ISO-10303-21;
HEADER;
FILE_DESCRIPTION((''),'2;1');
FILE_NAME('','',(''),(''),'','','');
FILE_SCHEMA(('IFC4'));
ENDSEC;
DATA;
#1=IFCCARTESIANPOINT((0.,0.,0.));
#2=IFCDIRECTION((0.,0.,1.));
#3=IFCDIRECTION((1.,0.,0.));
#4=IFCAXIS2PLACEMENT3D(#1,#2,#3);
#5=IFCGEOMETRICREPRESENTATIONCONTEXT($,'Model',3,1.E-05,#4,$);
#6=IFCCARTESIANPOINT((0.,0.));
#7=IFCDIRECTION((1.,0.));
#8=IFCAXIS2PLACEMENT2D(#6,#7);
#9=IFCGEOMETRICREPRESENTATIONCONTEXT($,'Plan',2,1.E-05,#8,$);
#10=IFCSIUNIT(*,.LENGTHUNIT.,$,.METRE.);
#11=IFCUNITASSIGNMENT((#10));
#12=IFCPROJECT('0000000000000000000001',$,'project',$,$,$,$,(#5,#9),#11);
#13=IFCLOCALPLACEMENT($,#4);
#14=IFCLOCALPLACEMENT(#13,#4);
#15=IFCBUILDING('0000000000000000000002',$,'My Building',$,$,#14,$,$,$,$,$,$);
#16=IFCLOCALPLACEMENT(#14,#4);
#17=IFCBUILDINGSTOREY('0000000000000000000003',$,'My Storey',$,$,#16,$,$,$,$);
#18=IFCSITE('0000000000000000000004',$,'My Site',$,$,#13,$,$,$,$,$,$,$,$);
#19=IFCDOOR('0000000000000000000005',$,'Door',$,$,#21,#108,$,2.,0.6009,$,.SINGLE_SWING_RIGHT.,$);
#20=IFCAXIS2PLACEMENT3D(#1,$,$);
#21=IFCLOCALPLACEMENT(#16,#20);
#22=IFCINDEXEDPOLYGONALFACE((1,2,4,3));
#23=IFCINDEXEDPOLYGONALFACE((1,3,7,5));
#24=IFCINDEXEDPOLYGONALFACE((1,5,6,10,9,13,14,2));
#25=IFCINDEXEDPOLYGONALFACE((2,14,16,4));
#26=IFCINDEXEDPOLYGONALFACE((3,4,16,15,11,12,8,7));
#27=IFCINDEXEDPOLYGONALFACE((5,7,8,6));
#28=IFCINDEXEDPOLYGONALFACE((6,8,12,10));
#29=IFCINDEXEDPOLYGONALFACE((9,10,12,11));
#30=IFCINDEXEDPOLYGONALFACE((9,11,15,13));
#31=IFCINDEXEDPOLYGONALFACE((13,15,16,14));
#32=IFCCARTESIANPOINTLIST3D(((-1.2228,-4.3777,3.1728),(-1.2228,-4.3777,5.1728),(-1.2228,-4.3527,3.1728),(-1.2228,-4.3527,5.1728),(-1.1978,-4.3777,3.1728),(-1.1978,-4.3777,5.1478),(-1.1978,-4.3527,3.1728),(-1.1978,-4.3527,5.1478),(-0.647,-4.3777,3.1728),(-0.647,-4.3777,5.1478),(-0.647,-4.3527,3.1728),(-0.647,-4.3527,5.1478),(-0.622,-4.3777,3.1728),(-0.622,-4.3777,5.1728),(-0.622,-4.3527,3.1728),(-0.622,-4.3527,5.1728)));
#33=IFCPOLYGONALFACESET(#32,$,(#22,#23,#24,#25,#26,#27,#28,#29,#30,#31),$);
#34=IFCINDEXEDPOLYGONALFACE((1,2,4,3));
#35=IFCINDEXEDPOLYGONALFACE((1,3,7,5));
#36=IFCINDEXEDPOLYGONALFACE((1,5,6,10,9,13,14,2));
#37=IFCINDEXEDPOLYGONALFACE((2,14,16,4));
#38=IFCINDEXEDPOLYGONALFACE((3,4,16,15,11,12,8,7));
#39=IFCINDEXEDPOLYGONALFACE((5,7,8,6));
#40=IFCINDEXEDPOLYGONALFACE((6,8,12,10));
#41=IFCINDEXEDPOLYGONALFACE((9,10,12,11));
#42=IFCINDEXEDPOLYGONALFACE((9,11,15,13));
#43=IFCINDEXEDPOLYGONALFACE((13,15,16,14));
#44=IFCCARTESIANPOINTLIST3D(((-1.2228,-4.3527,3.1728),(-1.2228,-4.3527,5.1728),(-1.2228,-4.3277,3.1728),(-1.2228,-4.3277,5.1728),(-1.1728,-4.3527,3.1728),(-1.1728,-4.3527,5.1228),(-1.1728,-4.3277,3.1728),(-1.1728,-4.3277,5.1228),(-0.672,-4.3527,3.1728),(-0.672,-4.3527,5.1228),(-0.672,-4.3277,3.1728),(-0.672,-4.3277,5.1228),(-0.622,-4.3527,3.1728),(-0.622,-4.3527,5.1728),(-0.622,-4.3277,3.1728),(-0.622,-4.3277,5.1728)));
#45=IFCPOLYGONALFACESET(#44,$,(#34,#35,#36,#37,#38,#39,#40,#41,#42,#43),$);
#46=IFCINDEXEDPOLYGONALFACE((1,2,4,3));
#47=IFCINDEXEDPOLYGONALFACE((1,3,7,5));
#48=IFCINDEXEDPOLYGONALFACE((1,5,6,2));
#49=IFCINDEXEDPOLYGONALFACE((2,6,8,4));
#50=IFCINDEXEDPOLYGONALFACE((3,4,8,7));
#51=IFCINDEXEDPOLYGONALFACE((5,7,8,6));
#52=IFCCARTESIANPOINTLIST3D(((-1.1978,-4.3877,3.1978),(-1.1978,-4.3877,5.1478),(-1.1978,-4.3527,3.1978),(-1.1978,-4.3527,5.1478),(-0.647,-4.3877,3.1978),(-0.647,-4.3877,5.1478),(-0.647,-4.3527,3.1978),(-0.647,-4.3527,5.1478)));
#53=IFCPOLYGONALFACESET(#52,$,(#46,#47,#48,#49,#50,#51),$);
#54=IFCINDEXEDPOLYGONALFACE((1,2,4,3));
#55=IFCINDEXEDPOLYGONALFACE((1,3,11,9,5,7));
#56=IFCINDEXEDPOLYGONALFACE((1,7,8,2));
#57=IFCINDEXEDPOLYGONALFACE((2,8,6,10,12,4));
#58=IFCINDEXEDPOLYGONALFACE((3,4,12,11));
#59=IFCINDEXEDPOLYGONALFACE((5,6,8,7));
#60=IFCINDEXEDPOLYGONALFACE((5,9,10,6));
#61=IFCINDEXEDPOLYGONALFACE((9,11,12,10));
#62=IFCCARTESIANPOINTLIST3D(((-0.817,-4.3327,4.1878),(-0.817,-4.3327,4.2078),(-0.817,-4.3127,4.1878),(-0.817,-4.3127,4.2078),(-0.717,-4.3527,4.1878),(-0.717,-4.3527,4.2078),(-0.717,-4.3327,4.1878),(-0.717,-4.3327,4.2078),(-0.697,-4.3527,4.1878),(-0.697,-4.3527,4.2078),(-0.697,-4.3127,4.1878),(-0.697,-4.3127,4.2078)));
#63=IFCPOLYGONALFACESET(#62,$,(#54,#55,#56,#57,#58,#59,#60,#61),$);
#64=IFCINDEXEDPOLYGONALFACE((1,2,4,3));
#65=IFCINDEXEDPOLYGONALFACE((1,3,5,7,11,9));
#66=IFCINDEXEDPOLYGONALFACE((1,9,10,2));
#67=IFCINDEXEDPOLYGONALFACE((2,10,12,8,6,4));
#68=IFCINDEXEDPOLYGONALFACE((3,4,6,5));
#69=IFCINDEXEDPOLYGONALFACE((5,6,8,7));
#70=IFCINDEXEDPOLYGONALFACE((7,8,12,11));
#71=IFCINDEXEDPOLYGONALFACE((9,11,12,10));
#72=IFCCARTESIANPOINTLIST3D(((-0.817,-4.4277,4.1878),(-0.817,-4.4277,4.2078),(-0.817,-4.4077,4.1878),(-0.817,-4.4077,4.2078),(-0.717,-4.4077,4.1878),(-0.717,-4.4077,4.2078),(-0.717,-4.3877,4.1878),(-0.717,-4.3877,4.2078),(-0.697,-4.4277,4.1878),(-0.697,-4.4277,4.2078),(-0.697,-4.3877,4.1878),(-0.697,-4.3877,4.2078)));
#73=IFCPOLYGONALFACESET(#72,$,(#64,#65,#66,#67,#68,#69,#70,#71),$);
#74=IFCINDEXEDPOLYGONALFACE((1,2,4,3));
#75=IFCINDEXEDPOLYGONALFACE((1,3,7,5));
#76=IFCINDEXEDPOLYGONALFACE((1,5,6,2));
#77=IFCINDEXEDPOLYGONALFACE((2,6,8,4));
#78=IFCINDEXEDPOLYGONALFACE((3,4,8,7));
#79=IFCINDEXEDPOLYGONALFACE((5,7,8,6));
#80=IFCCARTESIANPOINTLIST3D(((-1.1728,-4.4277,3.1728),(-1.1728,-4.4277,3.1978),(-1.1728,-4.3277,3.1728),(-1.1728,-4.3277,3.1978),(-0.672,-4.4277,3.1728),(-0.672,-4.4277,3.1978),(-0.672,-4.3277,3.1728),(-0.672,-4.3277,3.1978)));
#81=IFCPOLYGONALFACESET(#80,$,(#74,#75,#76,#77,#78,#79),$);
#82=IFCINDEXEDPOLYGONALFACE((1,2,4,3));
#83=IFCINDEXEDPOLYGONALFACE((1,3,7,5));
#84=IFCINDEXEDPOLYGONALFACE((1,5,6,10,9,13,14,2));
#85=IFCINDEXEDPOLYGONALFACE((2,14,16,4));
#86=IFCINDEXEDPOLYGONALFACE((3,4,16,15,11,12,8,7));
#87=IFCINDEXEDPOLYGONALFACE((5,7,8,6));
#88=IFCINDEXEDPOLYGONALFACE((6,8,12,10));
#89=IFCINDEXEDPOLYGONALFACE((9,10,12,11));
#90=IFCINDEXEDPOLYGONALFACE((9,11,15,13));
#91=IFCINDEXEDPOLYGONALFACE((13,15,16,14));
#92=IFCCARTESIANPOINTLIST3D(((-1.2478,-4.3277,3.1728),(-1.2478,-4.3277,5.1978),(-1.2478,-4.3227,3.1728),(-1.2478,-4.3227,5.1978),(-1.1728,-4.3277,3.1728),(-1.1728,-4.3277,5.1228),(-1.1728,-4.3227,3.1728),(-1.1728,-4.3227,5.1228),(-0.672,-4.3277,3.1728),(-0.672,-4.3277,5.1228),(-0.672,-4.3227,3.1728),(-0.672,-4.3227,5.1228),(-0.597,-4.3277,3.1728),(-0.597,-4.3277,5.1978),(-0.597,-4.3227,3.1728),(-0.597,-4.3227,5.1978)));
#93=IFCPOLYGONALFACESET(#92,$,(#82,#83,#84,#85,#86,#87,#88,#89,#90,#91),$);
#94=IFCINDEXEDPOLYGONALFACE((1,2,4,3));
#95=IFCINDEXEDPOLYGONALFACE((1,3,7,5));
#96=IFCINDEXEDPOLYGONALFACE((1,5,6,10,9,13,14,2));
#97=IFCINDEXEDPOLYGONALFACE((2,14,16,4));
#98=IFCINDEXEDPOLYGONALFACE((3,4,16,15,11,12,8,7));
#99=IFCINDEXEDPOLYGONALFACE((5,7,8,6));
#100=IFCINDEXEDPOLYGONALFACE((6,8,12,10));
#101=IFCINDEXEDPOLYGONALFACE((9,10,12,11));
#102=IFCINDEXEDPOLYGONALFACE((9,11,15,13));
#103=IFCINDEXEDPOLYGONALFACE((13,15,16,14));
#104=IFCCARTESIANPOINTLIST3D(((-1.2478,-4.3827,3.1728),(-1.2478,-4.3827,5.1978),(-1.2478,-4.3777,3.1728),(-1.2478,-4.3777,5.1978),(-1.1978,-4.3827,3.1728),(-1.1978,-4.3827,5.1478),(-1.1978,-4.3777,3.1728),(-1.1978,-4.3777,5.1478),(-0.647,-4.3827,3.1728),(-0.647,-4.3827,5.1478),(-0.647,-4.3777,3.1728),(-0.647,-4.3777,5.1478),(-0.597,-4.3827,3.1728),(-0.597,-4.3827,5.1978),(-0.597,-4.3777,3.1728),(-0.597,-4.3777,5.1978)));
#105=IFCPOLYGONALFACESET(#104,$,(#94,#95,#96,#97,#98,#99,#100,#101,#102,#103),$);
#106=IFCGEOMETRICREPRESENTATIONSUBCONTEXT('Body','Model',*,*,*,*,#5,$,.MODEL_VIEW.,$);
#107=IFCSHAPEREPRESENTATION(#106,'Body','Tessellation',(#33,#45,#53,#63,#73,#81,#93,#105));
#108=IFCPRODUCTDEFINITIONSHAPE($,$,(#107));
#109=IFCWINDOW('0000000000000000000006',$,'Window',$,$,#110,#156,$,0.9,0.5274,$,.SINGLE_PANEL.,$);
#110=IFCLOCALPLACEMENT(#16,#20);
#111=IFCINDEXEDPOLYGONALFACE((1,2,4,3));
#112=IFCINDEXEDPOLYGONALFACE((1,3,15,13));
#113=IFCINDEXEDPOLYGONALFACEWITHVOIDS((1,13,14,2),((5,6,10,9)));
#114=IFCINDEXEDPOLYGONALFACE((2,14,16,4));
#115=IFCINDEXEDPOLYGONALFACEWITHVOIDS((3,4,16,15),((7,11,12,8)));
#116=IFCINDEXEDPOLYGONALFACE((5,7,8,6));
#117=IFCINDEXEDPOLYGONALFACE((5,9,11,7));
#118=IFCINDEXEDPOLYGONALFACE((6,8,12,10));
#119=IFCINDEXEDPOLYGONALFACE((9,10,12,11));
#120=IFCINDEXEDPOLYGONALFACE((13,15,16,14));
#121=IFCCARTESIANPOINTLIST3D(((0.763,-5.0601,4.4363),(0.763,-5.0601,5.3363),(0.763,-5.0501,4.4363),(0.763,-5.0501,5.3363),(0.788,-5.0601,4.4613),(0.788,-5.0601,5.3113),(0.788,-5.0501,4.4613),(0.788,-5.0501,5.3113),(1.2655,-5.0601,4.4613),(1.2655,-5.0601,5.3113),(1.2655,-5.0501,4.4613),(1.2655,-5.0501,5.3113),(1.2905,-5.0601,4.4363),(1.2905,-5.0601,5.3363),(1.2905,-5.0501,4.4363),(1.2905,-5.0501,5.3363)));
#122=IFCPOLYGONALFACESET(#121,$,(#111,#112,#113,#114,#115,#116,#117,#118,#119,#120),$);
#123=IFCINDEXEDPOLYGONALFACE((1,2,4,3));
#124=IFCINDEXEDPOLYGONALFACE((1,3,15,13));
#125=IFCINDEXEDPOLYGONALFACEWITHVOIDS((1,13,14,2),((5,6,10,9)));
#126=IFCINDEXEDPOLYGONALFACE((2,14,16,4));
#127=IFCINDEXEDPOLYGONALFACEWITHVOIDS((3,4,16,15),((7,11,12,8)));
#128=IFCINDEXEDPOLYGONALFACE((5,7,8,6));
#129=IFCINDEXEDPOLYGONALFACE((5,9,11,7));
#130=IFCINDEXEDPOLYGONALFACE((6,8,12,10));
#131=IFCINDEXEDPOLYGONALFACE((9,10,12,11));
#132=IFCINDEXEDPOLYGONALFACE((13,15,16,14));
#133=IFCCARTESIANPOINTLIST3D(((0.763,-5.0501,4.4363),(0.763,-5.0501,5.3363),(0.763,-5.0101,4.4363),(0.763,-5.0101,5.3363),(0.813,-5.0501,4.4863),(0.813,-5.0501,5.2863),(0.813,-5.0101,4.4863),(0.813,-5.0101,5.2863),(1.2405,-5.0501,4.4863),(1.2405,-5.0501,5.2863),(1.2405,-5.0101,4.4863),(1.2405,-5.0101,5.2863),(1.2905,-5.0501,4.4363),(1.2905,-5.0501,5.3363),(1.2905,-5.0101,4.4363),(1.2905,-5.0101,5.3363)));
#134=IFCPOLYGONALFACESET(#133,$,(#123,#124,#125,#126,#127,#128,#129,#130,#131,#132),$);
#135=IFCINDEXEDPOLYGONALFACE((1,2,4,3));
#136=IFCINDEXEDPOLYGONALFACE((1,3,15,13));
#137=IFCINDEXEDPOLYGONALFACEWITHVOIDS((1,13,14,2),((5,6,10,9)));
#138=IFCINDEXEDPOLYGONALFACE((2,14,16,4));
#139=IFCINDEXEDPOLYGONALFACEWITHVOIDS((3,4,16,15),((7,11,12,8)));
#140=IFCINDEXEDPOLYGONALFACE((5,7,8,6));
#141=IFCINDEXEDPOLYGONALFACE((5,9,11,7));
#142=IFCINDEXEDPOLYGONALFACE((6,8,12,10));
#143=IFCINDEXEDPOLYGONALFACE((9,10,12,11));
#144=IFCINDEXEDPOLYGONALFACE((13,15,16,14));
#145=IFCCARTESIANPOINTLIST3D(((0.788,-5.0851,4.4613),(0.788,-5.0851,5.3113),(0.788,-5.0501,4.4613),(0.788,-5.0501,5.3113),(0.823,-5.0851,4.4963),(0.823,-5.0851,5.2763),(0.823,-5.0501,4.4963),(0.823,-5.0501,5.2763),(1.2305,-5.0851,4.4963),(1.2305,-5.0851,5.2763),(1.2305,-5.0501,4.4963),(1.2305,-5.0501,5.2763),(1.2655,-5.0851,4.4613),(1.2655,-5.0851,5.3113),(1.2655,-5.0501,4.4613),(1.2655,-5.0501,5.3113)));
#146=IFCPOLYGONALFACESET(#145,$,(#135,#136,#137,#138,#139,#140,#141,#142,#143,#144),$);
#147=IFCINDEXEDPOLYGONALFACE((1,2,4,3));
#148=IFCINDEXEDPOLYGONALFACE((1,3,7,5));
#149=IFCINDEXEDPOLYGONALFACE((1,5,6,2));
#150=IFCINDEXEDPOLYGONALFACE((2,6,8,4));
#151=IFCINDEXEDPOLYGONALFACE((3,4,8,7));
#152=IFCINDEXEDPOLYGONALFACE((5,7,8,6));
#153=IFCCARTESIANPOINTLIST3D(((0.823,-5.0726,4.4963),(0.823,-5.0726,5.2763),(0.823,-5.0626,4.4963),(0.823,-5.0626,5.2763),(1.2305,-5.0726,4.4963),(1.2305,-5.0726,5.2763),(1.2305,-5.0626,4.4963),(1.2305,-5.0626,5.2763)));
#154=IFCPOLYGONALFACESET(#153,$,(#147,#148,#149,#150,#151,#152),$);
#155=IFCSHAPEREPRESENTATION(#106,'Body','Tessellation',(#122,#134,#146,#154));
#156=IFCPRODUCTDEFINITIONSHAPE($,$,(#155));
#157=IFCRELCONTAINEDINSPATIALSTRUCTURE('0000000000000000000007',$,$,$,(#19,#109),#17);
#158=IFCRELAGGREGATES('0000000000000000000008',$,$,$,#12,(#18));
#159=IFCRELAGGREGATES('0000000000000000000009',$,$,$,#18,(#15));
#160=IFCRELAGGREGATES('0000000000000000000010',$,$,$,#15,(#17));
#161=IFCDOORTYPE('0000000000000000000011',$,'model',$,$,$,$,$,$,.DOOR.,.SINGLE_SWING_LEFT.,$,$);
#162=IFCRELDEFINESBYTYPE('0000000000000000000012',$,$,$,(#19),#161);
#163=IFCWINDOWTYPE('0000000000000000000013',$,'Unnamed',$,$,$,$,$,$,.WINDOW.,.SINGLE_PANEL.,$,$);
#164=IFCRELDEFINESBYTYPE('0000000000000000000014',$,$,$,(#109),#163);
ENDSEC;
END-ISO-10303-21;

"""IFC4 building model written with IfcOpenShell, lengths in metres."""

from ifc_helpers import new_model, entity, si_unit, frame, origin_with_axes, origin_2d_with_axis, place, context, subcontext, project, spatial, line, indexed_curve, outline, extrude, shape, source, transform, mapped, type_object, type_shapes, element, save


model = new_model("IFC4")

# Units and contexts
model_context = context("Model", 3, precision=1e-05, world=origin_with_axes())
plan_context = context("Plan", 2, precision=1e-05, world=origin_2d_with_axis())
body_context_1 = subcontext(model_context, "Body", "Model", "MODEL_VIEW")
body_context_2 = subcontext(plan_context, "Body", "Plan", "PLAN_VIEW")
ifc_project = project(units=[si_unit("LENGTHUNIT", "METRE")], contexts=[model_context, plan_context])

# Site, building, storey
site_placement = place(None, origin_with_axes())
site = spatial("IfcSite", under=ifc_project, at=site_placement, Name="My Site")
building_placement = place(site_placement, origin_with_axes())
building = spatial("IfcBuilding", under=site, at=building_placement, Name="My Building")
storey_placement = place(building_placement, origin_with_axes())
storey = spatial("IfcBuildingStorey", under=building, at=storey_placement, Name="My Storey")

# Shared definitions
door_type_1 = type_object("IfcDoorType", Name="model", OperationType="SINGLE_SWING_LEFT", PredefinedType="DOOR")
shared_shape_1 = source(origin_with_axes(), body_context_1, "Body", "SweptSolid", [
    extrude(outline(indexed_curve([(0.0, 0.0), (0.0, 2.0), (0.6009, 2.0), (0.6009, 0.0), (0.5759, 0.0), (0.5759, 1.975), (0.025, 1.975), (0.025, 0.0)], segments=[line(1, 2, 3, 4, 5, 6, 7, 8, 1)])), frame((0.0, 0.025, 0.0), z_axis=(0.0, -1.0, 0.0), x_axis=(1.0, 0.0, 0.0)), (0.0, 0.0, -1.0), 0.025),
    extrude(outline(indexed_curve([(0.0, 0.0), (0.0, 2.0), (0.6009, 2.0), (0.6009, 0.0), (0.5509, 0.0), (0.5509, 1.95), (0.05, 1.95), (0.05, 0.0)], segments=[line(1, 2, 3, 4, 5, 6, 7, 8, 1)])), frame((0.0, 0.0, 0.0), z_axis=(0.0, -1.0, 0.0), x_axis=(1.0, 0.0, 0.0)), (0.0, 0.0, -1.0), 0.025),
    extrude(outline(indexed_curve([(0.0, 0.0), (0.5509, 0.0), (0.5509, 0.035), (0.0, 0.035)], segments=[line(1, 2, 3, 4, 1)])), frame((0.025, 0.025, 0.025), z_axis=(0.0, 0.0, 1.0), x_axis=(1.0, 0.0, 0.0)), (0.0, 0.0, 1.0), 1.95),
    extrude(outline(indexed_curve([(0.0, 0.0), (0.0, -0.04), (0.12, -0.04), (0.12, -0.02), (0.02, -0.02), (0.02, 0.0)], segments=[line(1, 2, 3, 4, 5, 6, 1)])), frame((0.075, 0.025, 1.015), z_axis=(0.0, 0.0, 1.0), x_axis=(1.0, 0.0, 0.0)), (0.0, 0.0, 1.0), 0.02),
    extrude(outline(indexed_curve([(0.0, 0.0), (0.0, 0.04), (0.12, 0.04), (0.12, 0.02), (0.02, 0.02), (0.02, 0.0)], segments=[line(1, 2, 3, 4, 5, 6, 1)])), frame((0.075, 0.06, 1.015), z_axis=(0.0, 0.0, 1.0), x_axis=(1.0, 0.0, 0.0)), (0.0, 0.0, 1.0), 0.02),
    extrude(outline(indexed_curve([(0.0, 0.0), (0.5009, 0.0), (0.5009, 0.1), (0.0, 0.1)], segments=[line(1, 2, 3, 4, 1)])), frame((0.05, 0.0, 0.0), z_axis=(0.0, 0.0, 1.0), x_axis=(1.0, 0.0, 0.0)), (0.0, 0.0, 1.0), 0.025),
    extrude(outline(indexed_curve([(0.0, 0.0), (0.0, 2.025), (0.6509, 2.025), (0.6509, 0.0), (0.5759, 0.0), (0.5759, 1.95), (0.075, 1.95), (0.075, 0.0)], segments=[line(1, 2, 3, 4, 5, 6, 7, 8, 1)])), frame((-0.025, -0.005, 0.0), z_axis=(0.0, -1.0, 0.0), x_axis=(1.0, 0.0, 0.0)), (0.0, 0.0, -1.0), 0.005),
    extrude(outline(indexed_curve([(0.0, 0.0), (0.0, 2.025), (0.6509, 2.025), (0.6509, 0.0), (0.6009, 0.0), (0.6009, 1.975), (0.05, 1.975), (0.05, 0.0)], segments=[line(1, 2, 3, 4, 5, 6, 7, 8, 1)])), frame((-0.025, 0.05, 0.0), z_axis=(0.0, -1.0, 0.0), x_axis=(1.0, 0.0, 0.0)), (0.0, 0.0, -1.0), 0.005),
])
shared_shape_2 = source(origin_with_axes(), body_context_2, "Body", "Curve2D", [
    entity("IfcIndexedPolyCurve", entity("IfcCartesianPointList2D", [[0.0, 0.0], [0.0, 0.05], [0.025, 0.05], [0.025, 0.025], [0.05, 0.025], [0.05, 0.0]]), [entity("IfcLineIndex", [1, 2, 3, 4, 5, 6, 1])]),
    entity("IfcIndexedPolyCurve", entity("IfcCartesianPointList2D", [[0.6009, 0.0], [0.6009, 0.05], [0.5759, 0.05], [0.5759, 0.025], [0.5509, 0.025], [0.5509, 0.0]]), [entity("IfcLineIndex", [1, 2, 3, 4, 5, 6, 1])]),
    entity("IfcTrimmedCurve", entity("IfcEllipse", entity("IfcAxis2Placement2D", entity("IfcCartesianPoint", [0.5409, 0.05]), entity("IfcDirection", [1.0, 0.0])), 0.5159, 0.5509), [entity("IfcCartesianPoint", [0.5409, 0.6009])], [entity("IfcCartesianPoint", [0.025, 0.05])], True, "CARTESIAN"),
    entity("IfcIndexedPolyCurve", entity("IfcCartesianPointList2D", [[0.5759, 0.05], [0.5409, 0.05], [0.5409, 0.6009], [0.5759, 0.6009]]), [entity("IfcLineIndex", [1, 2, 3, 4, 1])]),
])
type_shapes(door_type_1, [shared_shape_1, shared_shape_2])

# Shared definitions
window_type_1 = type_object("IfcWindowType", Name="Unnamed", PartitioningType="SINGLE_PANEL", PredefinedType="WINDOW")
shared_shape_3 = source(origin_with_axes(), body_context_1, "Body", "SweptSolid", [
    extrude(outline(indexed_curve([(0.0, 0.0), (0.5274, 0.0), (0.5274, 0.9), (0.0, 0.9)], segments=[line(1, 2, 3, 4, 1)]), holes=[indexed_curve([(0.025, 0.025), (0.5024, 0.025), (0.5024, 0.875), (0.025, 0.875)], segments=[line(1, 2, 3, 4, 1)])]), frame((0.0, 0.09, 0.0), z_axis=(0.0, -1.0, 0.0), x_axis=(1.0, 0.0, 0.0)), (0.0, 0.0, -1.0), 0.01),
    extrude(outline(indexed_curve([(0.0, 0.0), (0.5274, 0.0), (0.5274, 0.9), (0.0, 0.9)], segments=[line(1, 2, 3, 4, 1)]), holes=[indexed_curve([(0.05, 0.05), (0.4774, 0.05), (0.4774, 0.85), (0.05, 0.85)], segments=[line(1, 2, 3, 4, 1)])]), frame((0.0, 0.05, 0.0), z_axis=(0.0, -1.0, 0.0), x_axis=(1.0, 0.0, 0.0)), (0.0, 0.0, -1.0), 0.04),
    extrude(outline(indexed_curve([(0.0, 0.0), (0.4774, 0.0), (0.4774, 0.85), (0.0, 0.85)], segments=[line(1, 2, 3, 4, 1)]), holes=[indexed_curve([(0.035, 0.035), (0.4424, 0.035), (0.4424, 0.815), (0.035, 0.815)], segments=[line(1, 2, 3, 4, 1)])]), frame((0.025, 0.09, 0.025), z_axis=(0.0, -1.0, 0.0), x_axis=(1.0, 0.0, 0.0)), (0.0, 0.0, -1.0), 0.035),
    extrude(outline(indexed_curve([(0.035, 0.035), (0.4424, 0.035), (0.4424, 0.815), (0.035, 0.815)], segments=[line(1, 2, 3, 4, 1)])), frame((0.025, 0.1025, 0.025), z_axis=(0.0, -1.0, 0.0), x_axis=(1.0, 0.0, 0.0)), (0.0, 0.0, -1.0), 0.01),
])
shared_shape_4 = source(origin_with_axes(), body_context_2, "Body", "Curve2D", [
    entity("IfcIndexedPolyCurve", entity("IfcCartesianPointList2D", [[0.05, 0.05], [0.4774, 0.05]])),
    entity("IfcIndexedPolyCurve", entity("IfcCartesianPointList2D", [[0.0, 0.1], [0.025, 0.1], [0.025, 0.09], [0.05, 0.09], [0.05, 0.05], [0.0, 0.05]]), [entity("IfcLineIndex", [1, 2, 3, 4, 5, 6, 1])]),
    entity("IfcIndexedPolyCurve", entity("IfcCartesianPointList2D", [[0.5274, 0.1], [0.5024, 0.1], [0.5024, 0.09], [0.4774, 0.09], [0.4774, 0.05], [0.5274, 0.05]]), [entity("IfcLineIndex", [1, 2, 3, 4, 5, 6, 1])]),
    entity("IfcIndexedPolyCurve", entity("IfcCartesianPointList2D", [[0.025, 0.09], [0.06, 0.09], [0.06, 0.125], [0.025, 0.125]]), [entity("IfcLineIndex", [1, 2, 3, 4, 1])]),
    entity("IfcIndexedPolyCurve", entity("IfcCartesianPointList2D", [[0.5024, 0.09], [0.4674, 0.09], [0.4674, 0.125], [0.5024, 0.125]]), [entity("IfcLineIndex", [1, 2, 3, 4, 1])]),
    entity("IfcIndexedPolyCurve", entity("IfcCartesianPointList2D", [[0.06, 0.09], [0.4674, 0.09]])),
    entity("IfcIndexedPolyCurve", entity("IfcCartesianPointList2D", [[0.06, 0.125], [0.4674, 0.125]])),
    entity("IfcIndexedPolyCurve", entity("IfcCartesianPointList2D", [[0.06, 0.1075], [0.4674, 0.1075]])),
])
type_shapes(window_type_1, [shared_shape_3, shared_shape_4])

# Door
door_1_placement = place(storey_placement, frame((-0.622, -4.3277, 3.1728), z_axis=(0.0, 0.0, 1.0), x_axis=(-1.0, 0.0, 0.0)))
element("IfcDoor", 1, at=door_1_placement, inside=storey, type_object=door_type_1, Name="Door", OperationType="SINGLE_SWING_RIGHT", OverallHeight=2.0, OverallWidth=0.6009, shapes=[
    shape(body_context_1, "Body", "MappedRepresentation", [mapped(shared_shape_1, transform((0.0, 0.0, 0.0), x_axis=(1.0, 0.0, 0.0), y_axis=(0.0, 1.0, 0.0), z_axis=(0.0, 0.0, 1.0), scale=1.0))]),
    shape(body_context_2, "Body", "MappedRepresentation", [mapped(shared_shape_2, transform((0.0, 0.0, 0.0), x_axis=(1.0, 0.0, 0.0), y_axis=(0.0, 1.0, 0.0), z_axis=(0.0, 0.0, 1.0), scale=1.0))]),
])

# Window
for number, where, z_axis, x_axis, name in (
    (2, (1.2905, -4.9601, 4.4363), (0.0, 0.0, 1.0), (-1.0, 0.0, 0.0), "Window"),
):
    element("IfcWindow", number, at=place(storey_placement, frame(where, z_axis=z_axis, x_axis=x_axis)), inside=storey, type_object=window_type_1, Name=name, OverallHeight=0.9, OverallWidth=0.5274, PartitioningType="SINGLE_PANEL", shapes=[
        shape(body_context_1, "Body", "MappedRepresentation", [mapped(shared_shape_3, transform((0.0, 0.0, 0.0), x_axis=(1.0, 0.0, 0.0), y_axis=(0.0, 1.0, 0.0), z_axis=(0.0, 0.0, 1.0), scale=1.0))]),
        shape(body_context_2, "Body", "MappedRepresentation", [mapped(shared_shape_4, transform((0.0, 0.0, 0.0), x_axis=(1.0, 0.0, 0.0), y_axis=(0.0, 1.0, 0.0), z_axis=(0.0, 0.0, 1.0), scale=1.0))]),
    ])

save(model, "model.ifc")
